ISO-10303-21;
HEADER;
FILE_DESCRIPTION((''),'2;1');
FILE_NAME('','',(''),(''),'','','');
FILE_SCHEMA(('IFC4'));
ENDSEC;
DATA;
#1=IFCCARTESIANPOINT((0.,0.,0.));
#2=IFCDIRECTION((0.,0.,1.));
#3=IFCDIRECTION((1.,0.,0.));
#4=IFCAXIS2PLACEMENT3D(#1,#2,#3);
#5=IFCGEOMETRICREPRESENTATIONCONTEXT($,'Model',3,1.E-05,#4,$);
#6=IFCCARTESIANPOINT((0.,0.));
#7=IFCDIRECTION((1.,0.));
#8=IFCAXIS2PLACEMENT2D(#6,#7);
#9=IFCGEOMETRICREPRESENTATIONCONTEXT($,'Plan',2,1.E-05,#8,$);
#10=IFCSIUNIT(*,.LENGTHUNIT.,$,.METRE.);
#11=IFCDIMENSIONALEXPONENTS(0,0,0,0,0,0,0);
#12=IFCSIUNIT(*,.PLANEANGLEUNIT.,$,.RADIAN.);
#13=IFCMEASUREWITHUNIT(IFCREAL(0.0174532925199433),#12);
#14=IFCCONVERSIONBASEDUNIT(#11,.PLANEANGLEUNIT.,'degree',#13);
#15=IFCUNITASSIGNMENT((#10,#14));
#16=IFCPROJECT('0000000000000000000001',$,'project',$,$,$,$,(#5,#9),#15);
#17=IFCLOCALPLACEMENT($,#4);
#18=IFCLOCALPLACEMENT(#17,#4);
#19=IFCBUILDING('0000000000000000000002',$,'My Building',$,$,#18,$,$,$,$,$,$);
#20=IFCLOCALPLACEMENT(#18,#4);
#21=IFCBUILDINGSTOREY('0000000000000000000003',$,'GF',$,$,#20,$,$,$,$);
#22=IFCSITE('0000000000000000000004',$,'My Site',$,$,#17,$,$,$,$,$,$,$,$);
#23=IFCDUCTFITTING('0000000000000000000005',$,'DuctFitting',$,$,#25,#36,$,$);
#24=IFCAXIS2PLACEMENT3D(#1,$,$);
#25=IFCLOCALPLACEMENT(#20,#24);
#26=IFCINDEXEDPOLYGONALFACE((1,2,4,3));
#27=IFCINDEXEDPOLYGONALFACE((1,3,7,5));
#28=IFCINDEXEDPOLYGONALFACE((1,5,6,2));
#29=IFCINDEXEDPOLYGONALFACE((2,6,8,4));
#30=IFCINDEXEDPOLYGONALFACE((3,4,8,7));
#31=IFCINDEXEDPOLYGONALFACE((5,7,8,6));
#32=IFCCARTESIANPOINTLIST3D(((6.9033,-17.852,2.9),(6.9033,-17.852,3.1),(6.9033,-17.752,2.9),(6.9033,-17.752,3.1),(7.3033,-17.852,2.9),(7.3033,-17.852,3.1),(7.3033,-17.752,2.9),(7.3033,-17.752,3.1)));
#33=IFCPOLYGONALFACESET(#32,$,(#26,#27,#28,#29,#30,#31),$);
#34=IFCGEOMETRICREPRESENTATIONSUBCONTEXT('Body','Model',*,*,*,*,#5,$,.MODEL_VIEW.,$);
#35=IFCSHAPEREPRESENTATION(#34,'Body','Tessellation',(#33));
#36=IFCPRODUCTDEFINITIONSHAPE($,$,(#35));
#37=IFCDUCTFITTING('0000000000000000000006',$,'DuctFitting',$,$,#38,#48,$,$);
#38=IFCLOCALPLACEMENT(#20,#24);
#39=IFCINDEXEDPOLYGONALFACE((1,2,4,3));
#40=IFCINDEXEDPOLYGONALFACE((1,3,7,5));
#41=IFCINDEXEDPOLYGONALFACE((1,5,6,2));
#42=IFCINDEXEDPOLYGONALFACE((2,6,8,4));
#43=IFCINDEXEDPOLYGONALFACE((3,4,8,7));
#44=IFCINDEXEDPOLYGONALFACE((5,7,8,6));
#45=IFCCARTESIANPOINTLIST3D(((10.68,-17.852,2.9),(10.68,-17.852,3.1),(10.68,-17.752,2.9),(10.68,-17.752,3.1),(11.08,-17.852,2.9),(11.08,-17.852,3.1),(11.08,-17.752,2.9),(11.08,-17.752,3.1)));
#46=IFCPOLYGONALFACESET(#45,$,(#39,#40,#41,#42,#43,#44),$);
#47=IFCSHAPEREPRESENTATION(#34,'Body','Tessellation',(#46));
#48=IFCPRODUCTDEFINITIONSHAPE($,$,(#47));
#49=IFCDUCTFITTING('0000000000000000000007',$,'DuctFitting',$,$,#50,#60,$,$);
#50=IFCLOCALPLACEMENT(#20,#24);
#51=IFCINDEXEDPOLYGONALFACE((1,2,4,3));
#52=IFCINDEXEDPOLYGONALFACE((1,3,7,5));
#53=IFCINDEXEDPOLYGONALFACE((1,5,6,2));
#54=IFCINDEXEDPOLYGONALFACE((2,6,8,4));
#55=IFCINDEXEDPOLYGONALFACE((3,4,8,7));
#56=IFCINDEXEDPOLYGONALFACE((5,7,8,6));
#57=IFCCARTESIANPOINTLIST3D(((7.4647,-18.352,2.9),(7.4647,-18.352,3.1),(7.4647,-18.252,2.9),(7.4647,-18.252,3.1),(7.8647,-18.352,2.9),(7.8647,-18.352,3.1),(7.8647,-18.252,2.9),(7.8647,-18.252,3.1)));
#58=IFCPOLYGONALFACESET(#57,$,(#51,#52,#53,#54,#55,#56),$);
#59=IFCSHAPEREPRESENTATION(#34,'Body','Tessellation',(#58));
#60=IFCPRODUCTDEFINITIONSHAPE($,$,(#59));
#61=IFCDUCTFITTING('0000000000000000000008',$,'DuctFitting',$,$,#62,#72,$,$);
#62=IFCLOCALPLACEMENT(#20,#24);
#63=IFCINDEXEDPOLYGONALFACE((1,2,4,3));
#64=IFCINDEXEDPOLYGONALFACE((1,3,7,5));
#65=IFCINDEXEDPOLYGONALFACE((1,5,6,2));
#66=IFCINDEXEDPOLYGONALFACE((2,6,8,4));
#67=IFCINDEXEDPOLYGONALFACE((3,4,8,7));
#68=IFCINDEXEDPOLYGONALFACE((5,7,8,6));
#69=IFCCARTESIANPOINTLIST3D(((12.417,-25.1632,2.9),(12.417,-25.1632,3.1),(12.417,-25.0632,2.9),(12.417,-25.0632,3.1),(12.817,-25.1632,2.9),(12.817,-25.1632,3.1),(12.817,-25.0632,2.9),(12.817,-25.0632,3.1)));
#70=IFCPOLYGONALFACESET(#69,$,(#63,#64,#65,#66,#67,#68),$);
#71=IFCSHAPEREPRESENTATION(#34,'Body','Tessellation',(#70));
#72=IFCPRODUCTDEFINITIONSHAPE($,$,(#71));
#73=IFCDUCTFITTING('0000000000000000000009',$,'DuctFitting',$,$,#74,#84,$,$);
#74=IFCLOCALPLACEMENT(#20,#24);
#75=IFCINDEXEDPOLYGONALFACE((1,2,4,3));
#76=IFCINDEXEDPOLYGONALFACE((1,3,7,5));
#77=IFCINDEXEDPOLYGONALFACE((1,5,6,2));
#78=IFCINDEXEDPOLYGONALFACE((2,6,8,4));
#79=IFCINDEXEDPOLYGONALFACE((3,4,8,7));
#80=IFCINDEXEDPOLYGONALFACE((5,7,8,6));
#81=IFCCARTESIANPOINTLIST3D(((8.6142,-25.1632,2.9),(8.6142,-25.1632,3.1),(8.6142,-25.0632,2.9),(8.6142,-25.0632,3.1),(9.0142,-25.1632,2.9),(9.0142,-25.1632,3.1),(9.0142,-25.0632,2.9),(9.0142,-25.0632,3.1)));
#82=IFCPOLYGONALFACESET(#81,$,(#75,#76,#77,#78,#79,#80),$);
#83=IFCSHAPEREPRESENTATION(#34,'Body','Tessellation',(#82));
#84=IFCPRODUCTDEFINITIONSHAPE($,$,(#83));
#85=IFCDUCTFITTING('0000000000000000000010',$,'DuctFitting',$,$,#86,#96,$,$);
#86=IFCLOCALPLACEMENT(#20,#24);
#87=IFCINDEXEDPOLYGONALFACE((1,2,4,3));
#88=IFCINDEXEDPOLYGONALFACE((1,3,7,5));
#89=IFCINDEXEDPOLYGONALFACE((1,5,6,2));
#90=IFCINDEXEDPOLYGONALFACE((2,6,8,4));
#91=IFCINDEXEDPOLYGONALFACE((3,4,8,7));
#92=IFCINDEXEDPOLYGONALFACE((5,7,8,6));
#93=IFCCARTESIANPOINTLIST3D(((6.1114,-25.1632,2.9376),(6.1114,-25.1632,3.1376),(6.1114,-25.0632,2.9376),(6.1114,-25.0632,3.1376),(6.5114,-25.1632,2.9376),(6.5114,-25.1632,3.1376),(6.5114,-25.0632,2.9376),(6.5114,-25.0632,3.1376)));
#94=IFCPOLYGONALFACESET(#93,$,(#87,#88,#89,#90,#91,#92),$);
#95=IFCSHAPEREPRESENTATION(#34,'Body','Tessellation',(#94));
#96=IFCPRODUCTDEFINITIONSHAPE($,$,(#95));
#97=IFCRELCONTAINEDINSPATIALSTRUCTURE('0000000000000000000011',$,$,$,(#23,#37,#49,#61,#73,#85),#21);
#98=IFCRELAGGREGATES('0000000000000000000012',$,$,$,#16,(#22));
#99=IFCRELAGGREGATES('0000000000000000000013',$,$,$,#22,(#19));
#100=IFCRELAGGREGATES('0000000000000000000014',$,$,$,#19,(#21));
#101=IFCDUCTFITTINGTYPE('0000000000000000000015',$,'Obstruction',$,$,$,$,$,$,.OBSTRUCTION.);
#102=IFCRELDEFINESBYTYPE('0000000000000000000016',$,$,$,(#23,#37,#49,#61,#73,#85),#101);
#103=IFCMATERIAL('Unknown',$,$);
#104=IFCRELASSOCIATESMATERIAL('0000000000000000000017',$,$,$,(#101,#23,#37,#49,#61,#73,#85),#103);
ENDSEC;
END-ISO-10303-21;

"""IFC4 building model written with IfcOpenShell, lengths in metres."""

from ifc_helpers import new_model, entity, si_unit, converted_unit, frame, origin_with_axes, origin_2d_with_axis, place, context, subcontext, project, spatial, rectangle, extrude, material, material_profile, profile_set, profile_usage, type_object, element, save


model = new_model("IFC4")

# Units and contexts
model_context = context("Model", 3, precision=1e-05, world=origin_with_axes())
plan_context = context("Plan", 2, precision=1e-05, world=origin_2d_with_axis())
body_context_1 = subcontext(model_context, "Body", "Model", "MODEL_VIEW")
ifc_project = project(units=[si_unit("LENGTHUNIT", "METRE"), converted_unit("PLANEANGLEUNIT", "degree", entity("IfcReal", 0.0174532925199433), si_unit("PLANEANGLEUNIT", "RADIAN"), dimensions=[0, 0, 0, 0, 0, 0, 0])], contexts=[model_context, plan_context])

# Site, building, storey
site_placement = place(None, origin_with_axes())
site = spatial("IfcSite", under=ifc_project, at=site_placement, Name="My Site")
building_placement = place(site_placement, origin_with_axes())
building = spatial("IfcBuilding", under=site, at=building_placement, Name="My Building")
storey_placement = place(building_placement, origin_with_axes())
storey = spatial("IfcBuildingStorey", under=building, at=storey_placement, Name="GF")

# Shared definitions
ifc_material = material(Name="Unknown")

# Duct fittings
ifc_material_profile_1 = material_profile(ifc_material, rectangle(XDim=0.4, YDim=0.2))
ifc_profile_set_1 = profile_set([ifc_material_profile_1])
duct_fitting_type = type_object("IfcDuctFittingType", Name="Obstruction", PredefinedType="OBSTRUCTION", material=ifc_profile_set_1)
ifc_profile_usage_1 = profile_usage(ifc_profile_set_1, cardinal=5)
duct_fitting_1_placement = place(storey_placement, frame((7.1033, -17.852, 3.0), z_axis=(0.0, 1.0, 0.0), x_axis=(-1.0, 0.0, 0.0)))
element("IfcDuctFitting", 1, at=duct_fitting_1_placement, inside=storey, type_object=duct_fitting_type, material=ifc_profile_usage_1, Name="DuctFitting", context=body_context_1, shape_type="SweptSolid", body=[
    extrude(rectangle(XDim=0.4, YDim=0.2), origin_with_axes(), (0.0, 0.0, 1.0), 0.1),
])
ifc_profile_usage_2 = profile_usage(ifc_profile_set_1, cardinal=5)
duct_fitting_2_placement = place(storey_placement, frame((10.88, -17.852, 3.0), z_axis=(0.0, 1.0, 0.0), x_axis=(-1.0, 0.0, 0.0)))
element("IfcDuctFitting", 2, at=duct_fitting_2_placement, inside=storey, type_object=duct_fitting_type, material=ifc_profile_usage_2, Name="DuctFitting", context=body_context_1, shape_type="SweptSolid", body=[
    extrude(rectangle(XDim=0.4, YDim=0.2), origin_with_axes(), (0.0, 0.0, 1.0), 0.1),
])
ifc_profile_usage_3 = profile_usage(ifc_profile_set_1, cardinal=5)
duct_fitting_3_placement = place(storey_placement, frame((7.6647, -18.252, 3.0), z_axis=(0.0, -1.0, 0.0), x_axis=(1.0, 0.0, 0.0)))
element("IfcDuctFitting", 3, at=duct_fitting_3_placement, inside=storey, type_object=duct_fitting_type, material=ifc_profile_usage_3, Name="DuctFitting", context=body_context_1, shape_type="SweptSolid", body=[
    extrude(rectangle(XDim=0.4, YDim=0.2), origin_with_axes(), (0.0, 0.0, 1.0), 0.1),
])
ifc_profile_usage_4 = profile_usage(ifc_profile_set_1, cardinal=5)
duct_fitting_4_placement = place(storey_placement, frame((12.617, -25.0632, 3.0), z_axis=(0.0, -1.0, 0.0), x_axis=(1.0, 0.0, 0.0)))
element("IfcDuctFitting", 4, at=duct_fitting_4_placement, inside=storey, type_object=duct_fitting_type, material=ifc_profile_usage_4, Name="DuctFitting", context=body_context_1, shape_type="SweptSolid", body=[
    extrude(rectangle(XDim=0.4, YDim=0.2), origin_with_axes(), (0.0, 0.0, 1.0), 0.1),
])
ifc_profile_usage_5 = profile_usage(ifc_profile_set_1, cardinal=5)
duct_fitting_5_placement = place(storey_placement, frame((8.8142, -25.0632, 3.0), z_axis=(0.0, -1.0, 0.0), x_axis=(1.0, 0.0, 0.0)))
element("IfcDuctFitting", 5, at=duct_fitting_5_placement, inside=storey, type_object=duct_fitting_type, material=ifc_profile_usage_5, Name="DuctFitting", context=body_context_1, shape_type="SweptSolid", body=[
    extrude(rectangle(XDim=0.4, YDim=0.2), origin_with_axes(), (0.0, 0.0, 1.0), 0.1),
])
ifc_profile_usage_6 = profile_usage(ifc_profile_set_1, cardinal=5)
duct_fitting_6_placement = place(storey_placement, frame((6.3114, -25.1632, 3.0376), z_axis=(0.0, 1.0, 0.0), x_axis=(-1.0, 0.0, 0.0)))
element("IfcDuctFitting", 6, at=duct_fitting_6_placement, inside=storey, type_object=duct_fitting_type, material=ifc_profile_usage_6, Name="DuctFitting", context=body_context_1, shape_type="SweptSolid", body=[
    extrude(rectangle(XDim=0.4, YDim=0.2), origin_with_axes(), (0.0, 0.0, 1.0), 0.1),
])

save(model, "model.ifc")
